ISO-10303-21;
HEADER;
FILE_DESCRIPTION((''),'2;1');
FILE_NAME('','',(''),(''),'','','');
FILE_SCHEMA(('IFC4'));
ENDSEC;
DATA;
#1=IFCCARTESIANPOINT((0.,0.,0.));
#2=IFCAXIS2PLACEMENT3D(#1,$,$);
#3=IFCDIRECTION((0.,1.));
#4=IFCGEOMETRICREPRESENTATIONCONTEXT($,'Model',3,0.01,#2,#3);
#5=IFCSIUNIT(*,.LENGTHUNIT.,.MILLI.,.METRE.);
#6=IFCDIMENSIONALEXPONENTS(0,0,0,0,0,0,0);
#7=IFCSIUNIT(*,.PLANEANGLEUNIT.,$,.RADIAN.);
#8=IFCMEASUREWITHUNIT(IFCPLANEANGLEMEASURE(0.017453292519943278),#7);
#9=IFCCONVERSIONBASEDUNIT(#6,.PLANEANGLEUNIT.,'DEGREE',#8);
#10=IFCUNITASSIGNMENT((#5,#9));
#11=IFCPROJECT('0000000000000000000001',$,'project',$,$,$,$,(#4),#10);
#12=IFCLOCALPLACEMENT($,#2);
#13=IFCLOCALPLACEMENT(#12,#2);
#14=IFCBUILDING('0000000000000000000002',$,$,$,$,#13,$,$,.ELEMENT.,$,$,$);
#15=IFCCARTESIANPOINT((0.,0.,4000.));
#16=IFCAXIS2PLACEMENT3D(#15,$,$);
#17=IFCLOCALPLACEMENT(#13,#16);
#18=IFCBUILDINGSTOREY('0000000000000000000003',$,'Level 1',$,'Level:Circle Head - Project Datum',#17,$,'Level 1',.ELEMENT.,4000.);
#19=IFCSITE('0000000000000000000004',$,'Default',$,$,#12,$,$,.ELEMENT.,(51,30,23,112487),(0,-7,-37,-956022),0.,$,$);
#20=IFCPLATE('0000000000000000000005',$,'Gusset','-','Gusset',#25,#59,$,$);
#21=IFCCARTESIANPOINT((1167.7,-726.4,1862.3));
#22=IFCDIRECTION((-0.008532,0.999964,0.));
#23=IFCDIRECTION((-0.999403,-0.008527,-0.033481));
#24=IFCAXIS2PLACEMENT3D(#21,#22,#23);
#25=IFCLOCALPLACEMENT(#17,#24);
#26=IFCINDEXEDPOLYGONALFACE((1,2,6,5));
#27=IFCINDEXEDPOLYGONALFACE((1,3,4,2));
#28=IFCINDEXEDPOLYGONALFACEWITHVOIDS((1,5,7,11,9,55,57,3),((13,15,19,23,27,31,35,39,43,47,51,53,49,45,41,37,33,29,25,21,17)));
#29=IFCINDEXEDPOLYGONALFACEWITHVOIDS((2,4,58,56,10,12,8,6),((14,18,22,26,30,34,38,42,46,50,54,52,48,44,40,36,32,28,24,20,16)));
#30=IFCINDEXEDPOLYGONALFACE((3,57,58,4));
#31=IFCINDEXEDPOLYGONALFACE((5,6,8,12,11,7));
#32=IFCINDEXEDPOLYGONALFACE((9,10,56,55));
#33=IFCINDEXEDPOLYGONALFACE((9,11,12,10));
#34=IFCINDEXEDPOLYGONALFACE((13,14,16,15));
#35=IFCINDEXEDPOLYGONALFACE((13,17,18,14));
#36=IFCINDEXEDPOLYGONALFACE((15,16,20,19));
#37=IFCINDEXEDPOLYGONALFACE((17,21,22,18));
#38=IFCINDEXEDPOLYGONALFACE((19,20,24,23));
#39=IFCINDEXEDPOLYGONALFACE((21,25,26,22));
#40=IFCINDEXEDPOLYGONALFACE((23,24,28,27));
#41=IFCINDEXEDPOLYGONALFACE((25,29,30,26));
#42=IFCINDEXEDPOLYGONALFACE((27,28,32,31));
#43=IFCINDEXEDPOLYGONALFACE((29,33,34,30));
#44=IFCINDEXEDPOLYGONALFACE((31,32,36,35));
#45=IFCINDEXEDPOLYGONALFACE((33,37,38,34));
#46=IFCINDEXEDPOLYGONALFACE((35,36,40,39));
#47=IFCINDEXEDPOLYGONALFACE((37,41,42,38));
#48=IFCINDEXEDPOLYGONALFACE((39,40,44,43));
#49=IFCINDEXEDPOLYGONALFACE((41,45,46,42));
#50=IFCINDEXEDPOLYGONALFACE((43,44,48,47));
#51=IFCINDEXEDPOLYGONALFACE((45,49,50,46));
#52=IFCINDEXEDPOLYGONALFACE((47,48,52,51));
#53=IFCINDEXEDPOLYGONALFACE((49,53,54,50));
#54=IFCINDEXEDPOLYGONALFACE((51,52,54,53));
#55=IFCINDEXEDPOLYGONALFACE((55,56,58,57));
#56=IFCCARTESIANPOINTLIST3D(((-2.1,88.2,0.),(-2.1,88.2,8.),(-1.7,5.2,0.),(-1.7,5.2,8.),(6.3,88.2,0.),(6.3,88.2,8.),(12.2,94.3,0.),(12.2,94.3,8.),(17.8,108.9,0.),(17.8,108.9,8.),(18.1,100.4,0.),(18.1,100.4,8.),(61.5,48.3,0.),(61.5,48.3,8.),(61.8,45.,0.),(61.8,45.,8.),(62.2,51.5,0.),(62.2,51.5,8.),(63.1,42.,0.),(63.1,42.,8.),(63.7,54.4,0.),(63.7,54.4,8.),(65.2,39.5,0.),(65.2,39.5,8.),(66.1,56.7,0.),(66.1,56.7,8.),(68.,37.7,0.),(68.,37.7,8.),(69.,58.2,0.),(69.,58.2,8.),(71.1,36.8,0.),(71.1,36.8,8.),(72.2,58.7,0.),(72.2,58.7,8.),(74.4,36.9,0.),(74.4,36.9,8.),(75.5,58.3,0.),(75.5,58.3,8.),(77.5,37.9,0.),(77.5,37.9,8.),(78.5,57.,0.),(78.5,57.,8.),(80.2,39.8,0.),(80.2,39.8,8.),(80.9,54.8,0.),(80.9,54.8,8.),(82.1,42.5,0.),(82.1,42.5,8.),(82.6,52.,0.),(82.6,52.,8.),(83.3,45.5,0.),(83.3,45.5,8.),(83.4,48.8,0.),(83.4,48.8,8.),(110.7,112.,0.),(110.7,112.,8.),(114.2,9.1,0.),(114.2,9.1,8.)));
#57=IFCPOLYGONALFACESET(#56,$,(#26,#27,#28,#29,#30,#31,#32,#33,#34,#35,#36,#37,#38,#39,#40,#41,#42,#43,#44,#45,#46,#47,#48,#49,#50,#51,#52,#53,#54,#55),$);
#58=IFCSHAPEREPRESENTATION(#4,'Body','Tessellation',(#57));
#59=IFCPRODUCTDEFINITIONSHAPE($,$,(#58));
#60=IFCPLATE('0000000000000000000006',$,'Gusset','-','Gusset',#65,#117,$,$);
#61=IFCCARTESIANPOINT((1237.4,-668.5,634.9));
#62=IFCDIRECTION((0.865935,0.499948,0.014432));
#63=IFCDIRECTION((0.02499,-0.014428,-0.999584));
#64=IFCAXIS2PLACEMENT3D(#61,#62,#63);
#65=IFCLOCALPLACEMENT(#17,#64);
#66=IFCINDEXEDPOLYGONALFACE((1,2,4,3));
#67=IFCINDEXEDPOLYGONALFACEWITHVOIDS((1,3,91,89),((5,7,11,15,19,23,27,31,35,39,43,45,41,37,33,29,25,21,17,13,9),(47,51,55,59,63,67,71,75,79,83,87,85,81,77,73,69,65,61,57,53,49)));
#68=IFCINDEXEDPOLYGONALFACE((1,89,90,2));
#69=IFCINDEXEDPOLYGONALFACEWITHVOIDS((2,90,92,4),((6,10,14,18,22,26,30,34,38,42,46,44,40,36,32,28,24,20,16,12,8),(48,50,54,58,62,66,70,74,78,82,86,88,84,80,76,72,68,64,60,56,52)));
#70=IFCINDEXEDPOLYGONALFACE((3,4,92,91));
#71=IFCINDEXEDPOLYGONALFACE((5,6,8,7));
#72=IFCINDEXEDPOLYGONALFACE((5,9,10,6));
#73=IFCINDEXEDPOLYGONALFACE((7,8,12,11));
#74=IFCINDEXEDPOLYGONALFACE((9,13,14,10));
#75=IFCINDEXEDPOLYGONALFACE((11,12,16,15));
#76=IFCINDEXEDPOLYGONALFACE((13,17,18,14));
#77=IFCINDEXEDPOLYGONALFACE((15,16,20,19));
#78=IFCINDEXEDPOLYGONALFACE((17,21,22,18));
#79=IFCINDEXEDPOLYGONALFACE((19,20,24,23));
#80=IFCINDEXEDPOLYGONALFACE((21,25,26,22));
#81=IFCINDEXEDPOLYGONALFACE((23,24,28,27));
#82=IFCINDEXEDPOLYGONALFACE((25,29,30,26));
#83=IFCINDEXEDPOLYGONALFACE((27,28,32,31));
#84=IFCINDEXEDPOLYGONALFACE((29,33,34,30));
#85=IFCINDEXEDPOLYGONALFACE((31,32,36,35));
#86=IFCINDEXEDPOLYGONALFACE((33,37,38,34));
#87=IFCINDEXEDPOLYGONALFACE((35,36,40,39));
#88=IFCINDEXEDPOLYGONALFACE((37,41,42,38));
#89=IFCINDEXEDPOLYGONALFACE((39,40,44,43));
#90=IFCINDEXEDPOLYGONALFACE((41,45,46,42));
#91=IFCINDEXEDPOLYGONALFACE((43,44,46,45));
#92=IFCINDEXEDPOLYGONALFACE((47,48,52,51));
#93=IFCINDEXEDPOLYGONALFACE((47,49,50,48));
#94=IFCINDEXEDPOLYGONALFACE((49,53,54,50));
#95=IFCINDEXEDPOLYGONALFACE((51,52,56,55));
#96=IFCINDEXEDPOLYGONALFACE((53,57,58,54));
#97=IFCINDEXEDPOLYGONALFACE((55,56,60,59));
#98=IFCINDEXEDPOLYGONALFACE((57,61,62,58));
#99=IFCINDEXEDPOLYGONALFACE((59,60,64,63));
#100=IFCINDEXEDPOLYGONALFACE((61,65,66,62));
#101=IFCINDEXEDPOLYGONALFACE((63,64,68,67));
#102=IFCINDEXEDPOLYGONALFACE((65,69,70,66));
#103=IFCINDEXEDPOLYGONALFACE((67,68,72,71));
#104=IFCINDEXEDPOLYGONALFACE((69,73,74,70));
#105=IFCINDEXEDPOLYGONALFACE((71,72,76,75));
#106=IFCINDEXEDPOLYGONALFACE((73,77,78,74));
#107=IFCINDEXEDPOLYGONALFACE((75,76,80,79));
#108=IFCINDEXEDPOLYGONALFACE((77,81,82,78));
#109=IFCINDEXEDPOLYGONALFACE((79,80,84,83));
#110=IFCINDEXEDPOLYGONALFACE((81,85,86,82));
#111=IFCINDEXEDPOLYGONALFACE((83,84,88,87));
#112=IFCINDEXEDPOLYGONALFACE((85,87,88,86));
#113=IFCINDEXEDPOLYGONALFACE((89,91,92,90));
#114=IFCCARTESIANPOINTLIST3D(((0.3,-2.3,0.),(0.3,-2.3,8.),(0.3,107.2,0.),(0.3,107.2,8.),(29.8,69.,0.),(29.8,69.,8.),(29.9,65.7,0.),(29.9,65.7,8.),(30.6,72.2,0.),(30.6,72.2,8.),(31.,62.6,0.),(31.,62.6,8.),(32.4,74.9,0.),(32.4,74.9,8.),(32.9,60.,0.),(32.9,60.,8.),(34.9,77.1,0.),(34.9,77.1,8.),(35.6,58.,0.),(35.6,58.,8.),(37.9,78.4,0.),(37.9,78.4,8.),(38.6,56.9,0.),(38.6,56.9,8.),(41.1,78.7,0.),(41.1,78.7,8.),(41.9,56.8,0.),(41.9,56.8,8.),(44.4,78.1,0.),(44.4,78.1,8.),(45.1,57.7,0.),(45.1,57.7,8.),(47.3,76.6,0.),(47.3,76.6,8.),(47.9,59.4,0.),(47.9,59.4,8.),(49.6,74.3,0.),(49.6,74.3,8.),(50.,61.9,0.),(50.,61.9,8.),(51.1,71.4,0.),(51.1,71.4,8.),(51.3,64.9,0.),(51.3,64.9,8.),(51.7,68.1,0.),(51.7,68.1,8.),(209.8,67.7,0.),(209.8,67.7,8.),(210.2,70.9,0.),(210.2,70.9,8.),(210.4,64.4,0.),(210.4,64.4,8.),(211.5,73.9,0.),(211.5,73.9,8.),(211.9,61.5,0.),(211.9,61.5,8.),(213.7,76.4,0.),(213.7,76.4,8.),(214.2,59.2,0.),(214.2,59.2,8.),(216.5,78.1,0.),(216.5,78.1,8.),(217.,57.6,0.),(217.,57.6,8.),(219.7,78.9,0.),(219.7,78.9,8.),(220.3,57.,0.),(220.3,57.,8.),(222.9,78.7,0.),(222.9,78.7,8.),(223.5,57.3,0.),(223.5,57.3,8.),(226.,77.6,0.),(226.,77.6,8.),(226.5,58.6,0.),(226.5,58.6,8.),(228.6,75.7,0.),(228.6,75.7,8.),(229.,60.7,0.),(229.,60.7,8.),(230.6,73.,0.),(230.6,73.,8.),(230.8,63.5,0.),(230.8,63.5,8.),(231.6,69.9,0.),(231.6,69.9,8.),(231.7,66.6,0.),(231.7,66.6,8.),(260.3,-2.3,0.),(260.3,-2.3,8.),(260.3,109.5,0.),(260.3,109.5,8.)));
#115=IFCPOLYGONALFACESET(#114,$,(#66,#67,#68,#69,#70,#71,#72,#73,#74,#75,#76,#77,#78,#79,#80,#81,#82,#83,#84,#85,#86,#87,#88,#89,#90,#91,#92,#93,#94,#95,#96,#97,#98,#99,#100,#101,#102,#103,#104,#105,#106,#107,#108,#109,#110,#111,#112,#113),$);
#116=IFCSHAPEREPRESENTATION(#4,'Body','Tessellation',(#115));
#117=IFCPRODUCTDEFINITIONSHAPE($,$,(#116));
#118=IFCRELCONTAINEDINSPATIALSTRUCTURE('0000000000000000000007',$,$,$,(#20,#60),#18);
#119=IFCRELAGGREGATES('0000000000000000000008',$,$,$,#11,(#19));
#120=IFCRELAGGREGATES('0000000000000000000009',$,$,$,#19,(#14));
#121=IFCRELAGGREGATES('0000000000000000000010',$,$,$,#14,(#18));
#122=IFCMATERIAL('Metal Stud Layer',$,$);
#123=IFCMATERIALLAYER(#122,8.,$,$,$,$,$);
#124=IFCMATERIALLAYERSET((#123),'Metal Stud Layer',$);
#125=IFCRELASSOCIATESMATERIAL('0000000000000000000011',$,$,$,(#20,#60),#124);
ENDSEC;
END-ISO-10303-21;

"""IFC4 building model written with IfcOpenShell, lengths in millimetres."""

from ifc_helpers import new_model, entity, si_unit, converted_unit, point, direction, frame, frame_2d, origin, origin_with_axes, origin_2d_with_axis, place, context, project, spatial, polyline, circle_curve, line_curve, trimmed, segment, composite_curve, circle, outline, extrude, material, layer, layer_set, element, save


model = new_model("IFC4")

# Units and contexts
model_context = context("Model", 3, precision=0.01, world=origin(), true_north=direction((0.0, 1.0)))
ifc_project = project(units=[si_unit("LENGTHUNIT", "METRE", prefix="MILLI"), converted_unit("PLANEANGLEUNIT", "DEGREE", entity("IfcPlaneAngleMeasure", 0.017453292519943278), si_unit("PLANEANGLEUNIT", "RADIAN"), dimensions=[0, 0, 0, 0, 0, 0, 0])], contexts=[model_context])

# Site, building, storey
site_placement = place(None, origin())
site = spatial("IfcSite", under=ifc_project, at=site_placement, Name="Default", CompositionType="ELEMENT", RefLatitude=(51, 30, 23, 112487), RefLongitude=(0, -7, -37, -956022), RefElevation=0.0)
building_placement = place(site_placement, origin())
building = spatial("IfcBuilding", under=site, at=building_placement, CompositionType="ELEMENT")
storey_placement = place(building_placement, frame((0.0, 0.0, 4000.0)))
storey = spatial("IfcBuildingStorey", under=building, at=storey_placement, Name="Level 1", ObjectType="Level:Circle Head - Project Datum", LongName="Level 1", CompositionType="ELEMENT", Elevation=4000.0)

# Plate, openings
ifc_material_1 = material(Name="Metal Stud Layer")
ifc_layer_1 = layer(ifc_material_1, 8.0)
ifc_layer_set_1 = layer_set([ifc_layer_1], Name="Metal Stud Layer")
plate_1_placement = place(storey_placement, frame((1167.7, -726.4, 1862.3), z_axis=(-0.008532, 0.999964, 0.0), x_axis=(-0.999403, -0.008527, -0.033481)))
plate_1 = element("IfcPlate", 1, at=plate_1_placement, inside=storey, material=ifc_layer_set_1, Name="Gusset", Description="-", ObjectType="Gusset", context=model_context, shape_type="SweptSolid", body=[
    extrude(outline(polyline([(18.1, 100.4), (6.3, 88.2), (-2.1, 88.2), (-1.7, 5.2), (114.2, 9.1), (110.7, 112.0), (17.8, 108.9), (18.1, 100.4)])), origin_with_axes(), (0.0, 0.0, 1.0), 8.0),
])
opening_1_placement = place(plate_1_placement, origin_with_axes())
element("IfcOpeningElement", 2, at=opening_1_placement, cuts=plate_1, ObjectType="Opening", context=model_context, shape_type="SweptSolid", body=[
    extrude(outline(composite_curve([segment(trimmed(line_curve((18.1, 100.4), (-0.693597, -0.720363), 8.455359), [point((18.1, 100.4))], [point((12.2, 94.3))], True, "CARTESIAN"), True, "CONTINUOUS"), segment(trimmed(circle_curve(frame_2d((-2.2, 108.2), x_axis=(1.0, 0.0)), 20.0), [point((12.2, 94.3))], [point((17.8, 108.9))], True, "CARTESIAN"), True, "CONTINUOUS"), segment(trimmed(line_curve((17.8, 108.9), (0.033481, -0.999439), 8.455359), [point((17.8, 108.9))], [point((18.1, 100.4))], True, "CARTESIAN"), True, "CONTINUOUS")], self_intersect="UNKNOWN")), origin(), (0.0, 0.0, 1.0), 8.0),
])
opening_2_placement = place(plate_1_placement, origin_with_axes())
element("IfcOpeningElement", 3, at=opening_2_placement, cuts=plate_1, ObjectType="Opening", context=model_context, shape_type="SweptSolid", body=[
    extrude(outline(composite_curve([segment(trimmed(line_curve((6.3, 88.2), (-0.99999, -0.004369), 8.455359), [point((6.3, 88.2))], [point((-2.1, 88.2))], True, "CARTESIAN"), True, "CONTINUOUS"), segment(trimmed(circle_curve(frame_2d((-2.2, 108.2), x_axis=(1.0, 0.0)), 20.0), [point((-2.1, 88.2))], [point((12.2, 94.3))], True, "CARTESIAN"), True, "CONTINUOUS"), segment(trimmed(line_curve((12.2, 94.3), (-0.693597, -0.720363), 8.455359), [point((12.2, 94.3))], [point((6.3, 88.2))], True, "CARTESIAN"), True, "CONTINUOUS")], self_intersect="UNKNOWN")), origin(), (0.0, 0.0, 1.0), 8.0),
])
opening_3_placement = place(plate_1_placement, frame((72.5, 47.7, -0.5), z_axis=(0.0, 0.0, 1.0), x_axis=(0.877405, -0.479751, 0.0)))
element("IfcOpeningElement", 4, at=opening_3_placement, cuts=plate_1, ObjectType="Opening", context=model_context, shape_type="SweptSolid", body=[
    extrude(circle(Radius=11.0, at=origin_2d_with_axis()), origin(), (0.0, 0.0, 1.0), 9.0),
])

# Plate, openings
plate_2_placement = place(storey_placement, frame((1237.4, -668.5, 634.9), z_axis=(0.865935, 0.499948, 0.014432), x_axis=(0.02499, -0.014428, -0.999584)))
plate_2 = element("IfcPlate", 5, at=plate_2_placement, inside=storey, material=ifc_layer_set_1, Name="Gusset", Description="-", ObjectType="Gusset", context=model_context, shape_type="SweptSolid", body=[
    extrude(outline(polyline([(0.3, -2.3), (260.3, -2.3), (260.3, 109.5), (0.3, 107.2), (0.3, -2.3)])), origin_with_axes(), (0.0, 0.0, 1.0), 8.0),
])
opening_4_placement = place(plate_2_placement, frame((220.8, 68.0, 8.5), z_axis=(0.0, 0.0, -1.0), x_axis=(0.476137, 0.879371, 0.0)))
element("IfcOpeningElement", 6, at=opening_4_placement, cuts=plate_2, ObjectType="Opening", context=model_context, shape_type="SweptSolid", body=[
    extrude(circle(Radius=11.0, at=origin_2d_with_axis()), origin(), (0.0, 0.0, 1.0), 9.0),
])
opening_5_placement = place(plate_2_placement, frame((40.7, 67.8, 8.5), z_axis=(0.0, 0.0, -1.0), x_axis=(-0.530273, 0.847827, 0.0)))
element("IfcOpeningElement", 7, at=opening_5_placement, cuts=plate_2, ObjectType="Opening", context=model_context, shape_type="SweptSolid", body=[
    extrude(circle(Radius=11.0, at=origin_2d_with_axis()), origin(), (0.0, 0.0, 1.0), 9.0),
])

save(model, "model.ifc")
